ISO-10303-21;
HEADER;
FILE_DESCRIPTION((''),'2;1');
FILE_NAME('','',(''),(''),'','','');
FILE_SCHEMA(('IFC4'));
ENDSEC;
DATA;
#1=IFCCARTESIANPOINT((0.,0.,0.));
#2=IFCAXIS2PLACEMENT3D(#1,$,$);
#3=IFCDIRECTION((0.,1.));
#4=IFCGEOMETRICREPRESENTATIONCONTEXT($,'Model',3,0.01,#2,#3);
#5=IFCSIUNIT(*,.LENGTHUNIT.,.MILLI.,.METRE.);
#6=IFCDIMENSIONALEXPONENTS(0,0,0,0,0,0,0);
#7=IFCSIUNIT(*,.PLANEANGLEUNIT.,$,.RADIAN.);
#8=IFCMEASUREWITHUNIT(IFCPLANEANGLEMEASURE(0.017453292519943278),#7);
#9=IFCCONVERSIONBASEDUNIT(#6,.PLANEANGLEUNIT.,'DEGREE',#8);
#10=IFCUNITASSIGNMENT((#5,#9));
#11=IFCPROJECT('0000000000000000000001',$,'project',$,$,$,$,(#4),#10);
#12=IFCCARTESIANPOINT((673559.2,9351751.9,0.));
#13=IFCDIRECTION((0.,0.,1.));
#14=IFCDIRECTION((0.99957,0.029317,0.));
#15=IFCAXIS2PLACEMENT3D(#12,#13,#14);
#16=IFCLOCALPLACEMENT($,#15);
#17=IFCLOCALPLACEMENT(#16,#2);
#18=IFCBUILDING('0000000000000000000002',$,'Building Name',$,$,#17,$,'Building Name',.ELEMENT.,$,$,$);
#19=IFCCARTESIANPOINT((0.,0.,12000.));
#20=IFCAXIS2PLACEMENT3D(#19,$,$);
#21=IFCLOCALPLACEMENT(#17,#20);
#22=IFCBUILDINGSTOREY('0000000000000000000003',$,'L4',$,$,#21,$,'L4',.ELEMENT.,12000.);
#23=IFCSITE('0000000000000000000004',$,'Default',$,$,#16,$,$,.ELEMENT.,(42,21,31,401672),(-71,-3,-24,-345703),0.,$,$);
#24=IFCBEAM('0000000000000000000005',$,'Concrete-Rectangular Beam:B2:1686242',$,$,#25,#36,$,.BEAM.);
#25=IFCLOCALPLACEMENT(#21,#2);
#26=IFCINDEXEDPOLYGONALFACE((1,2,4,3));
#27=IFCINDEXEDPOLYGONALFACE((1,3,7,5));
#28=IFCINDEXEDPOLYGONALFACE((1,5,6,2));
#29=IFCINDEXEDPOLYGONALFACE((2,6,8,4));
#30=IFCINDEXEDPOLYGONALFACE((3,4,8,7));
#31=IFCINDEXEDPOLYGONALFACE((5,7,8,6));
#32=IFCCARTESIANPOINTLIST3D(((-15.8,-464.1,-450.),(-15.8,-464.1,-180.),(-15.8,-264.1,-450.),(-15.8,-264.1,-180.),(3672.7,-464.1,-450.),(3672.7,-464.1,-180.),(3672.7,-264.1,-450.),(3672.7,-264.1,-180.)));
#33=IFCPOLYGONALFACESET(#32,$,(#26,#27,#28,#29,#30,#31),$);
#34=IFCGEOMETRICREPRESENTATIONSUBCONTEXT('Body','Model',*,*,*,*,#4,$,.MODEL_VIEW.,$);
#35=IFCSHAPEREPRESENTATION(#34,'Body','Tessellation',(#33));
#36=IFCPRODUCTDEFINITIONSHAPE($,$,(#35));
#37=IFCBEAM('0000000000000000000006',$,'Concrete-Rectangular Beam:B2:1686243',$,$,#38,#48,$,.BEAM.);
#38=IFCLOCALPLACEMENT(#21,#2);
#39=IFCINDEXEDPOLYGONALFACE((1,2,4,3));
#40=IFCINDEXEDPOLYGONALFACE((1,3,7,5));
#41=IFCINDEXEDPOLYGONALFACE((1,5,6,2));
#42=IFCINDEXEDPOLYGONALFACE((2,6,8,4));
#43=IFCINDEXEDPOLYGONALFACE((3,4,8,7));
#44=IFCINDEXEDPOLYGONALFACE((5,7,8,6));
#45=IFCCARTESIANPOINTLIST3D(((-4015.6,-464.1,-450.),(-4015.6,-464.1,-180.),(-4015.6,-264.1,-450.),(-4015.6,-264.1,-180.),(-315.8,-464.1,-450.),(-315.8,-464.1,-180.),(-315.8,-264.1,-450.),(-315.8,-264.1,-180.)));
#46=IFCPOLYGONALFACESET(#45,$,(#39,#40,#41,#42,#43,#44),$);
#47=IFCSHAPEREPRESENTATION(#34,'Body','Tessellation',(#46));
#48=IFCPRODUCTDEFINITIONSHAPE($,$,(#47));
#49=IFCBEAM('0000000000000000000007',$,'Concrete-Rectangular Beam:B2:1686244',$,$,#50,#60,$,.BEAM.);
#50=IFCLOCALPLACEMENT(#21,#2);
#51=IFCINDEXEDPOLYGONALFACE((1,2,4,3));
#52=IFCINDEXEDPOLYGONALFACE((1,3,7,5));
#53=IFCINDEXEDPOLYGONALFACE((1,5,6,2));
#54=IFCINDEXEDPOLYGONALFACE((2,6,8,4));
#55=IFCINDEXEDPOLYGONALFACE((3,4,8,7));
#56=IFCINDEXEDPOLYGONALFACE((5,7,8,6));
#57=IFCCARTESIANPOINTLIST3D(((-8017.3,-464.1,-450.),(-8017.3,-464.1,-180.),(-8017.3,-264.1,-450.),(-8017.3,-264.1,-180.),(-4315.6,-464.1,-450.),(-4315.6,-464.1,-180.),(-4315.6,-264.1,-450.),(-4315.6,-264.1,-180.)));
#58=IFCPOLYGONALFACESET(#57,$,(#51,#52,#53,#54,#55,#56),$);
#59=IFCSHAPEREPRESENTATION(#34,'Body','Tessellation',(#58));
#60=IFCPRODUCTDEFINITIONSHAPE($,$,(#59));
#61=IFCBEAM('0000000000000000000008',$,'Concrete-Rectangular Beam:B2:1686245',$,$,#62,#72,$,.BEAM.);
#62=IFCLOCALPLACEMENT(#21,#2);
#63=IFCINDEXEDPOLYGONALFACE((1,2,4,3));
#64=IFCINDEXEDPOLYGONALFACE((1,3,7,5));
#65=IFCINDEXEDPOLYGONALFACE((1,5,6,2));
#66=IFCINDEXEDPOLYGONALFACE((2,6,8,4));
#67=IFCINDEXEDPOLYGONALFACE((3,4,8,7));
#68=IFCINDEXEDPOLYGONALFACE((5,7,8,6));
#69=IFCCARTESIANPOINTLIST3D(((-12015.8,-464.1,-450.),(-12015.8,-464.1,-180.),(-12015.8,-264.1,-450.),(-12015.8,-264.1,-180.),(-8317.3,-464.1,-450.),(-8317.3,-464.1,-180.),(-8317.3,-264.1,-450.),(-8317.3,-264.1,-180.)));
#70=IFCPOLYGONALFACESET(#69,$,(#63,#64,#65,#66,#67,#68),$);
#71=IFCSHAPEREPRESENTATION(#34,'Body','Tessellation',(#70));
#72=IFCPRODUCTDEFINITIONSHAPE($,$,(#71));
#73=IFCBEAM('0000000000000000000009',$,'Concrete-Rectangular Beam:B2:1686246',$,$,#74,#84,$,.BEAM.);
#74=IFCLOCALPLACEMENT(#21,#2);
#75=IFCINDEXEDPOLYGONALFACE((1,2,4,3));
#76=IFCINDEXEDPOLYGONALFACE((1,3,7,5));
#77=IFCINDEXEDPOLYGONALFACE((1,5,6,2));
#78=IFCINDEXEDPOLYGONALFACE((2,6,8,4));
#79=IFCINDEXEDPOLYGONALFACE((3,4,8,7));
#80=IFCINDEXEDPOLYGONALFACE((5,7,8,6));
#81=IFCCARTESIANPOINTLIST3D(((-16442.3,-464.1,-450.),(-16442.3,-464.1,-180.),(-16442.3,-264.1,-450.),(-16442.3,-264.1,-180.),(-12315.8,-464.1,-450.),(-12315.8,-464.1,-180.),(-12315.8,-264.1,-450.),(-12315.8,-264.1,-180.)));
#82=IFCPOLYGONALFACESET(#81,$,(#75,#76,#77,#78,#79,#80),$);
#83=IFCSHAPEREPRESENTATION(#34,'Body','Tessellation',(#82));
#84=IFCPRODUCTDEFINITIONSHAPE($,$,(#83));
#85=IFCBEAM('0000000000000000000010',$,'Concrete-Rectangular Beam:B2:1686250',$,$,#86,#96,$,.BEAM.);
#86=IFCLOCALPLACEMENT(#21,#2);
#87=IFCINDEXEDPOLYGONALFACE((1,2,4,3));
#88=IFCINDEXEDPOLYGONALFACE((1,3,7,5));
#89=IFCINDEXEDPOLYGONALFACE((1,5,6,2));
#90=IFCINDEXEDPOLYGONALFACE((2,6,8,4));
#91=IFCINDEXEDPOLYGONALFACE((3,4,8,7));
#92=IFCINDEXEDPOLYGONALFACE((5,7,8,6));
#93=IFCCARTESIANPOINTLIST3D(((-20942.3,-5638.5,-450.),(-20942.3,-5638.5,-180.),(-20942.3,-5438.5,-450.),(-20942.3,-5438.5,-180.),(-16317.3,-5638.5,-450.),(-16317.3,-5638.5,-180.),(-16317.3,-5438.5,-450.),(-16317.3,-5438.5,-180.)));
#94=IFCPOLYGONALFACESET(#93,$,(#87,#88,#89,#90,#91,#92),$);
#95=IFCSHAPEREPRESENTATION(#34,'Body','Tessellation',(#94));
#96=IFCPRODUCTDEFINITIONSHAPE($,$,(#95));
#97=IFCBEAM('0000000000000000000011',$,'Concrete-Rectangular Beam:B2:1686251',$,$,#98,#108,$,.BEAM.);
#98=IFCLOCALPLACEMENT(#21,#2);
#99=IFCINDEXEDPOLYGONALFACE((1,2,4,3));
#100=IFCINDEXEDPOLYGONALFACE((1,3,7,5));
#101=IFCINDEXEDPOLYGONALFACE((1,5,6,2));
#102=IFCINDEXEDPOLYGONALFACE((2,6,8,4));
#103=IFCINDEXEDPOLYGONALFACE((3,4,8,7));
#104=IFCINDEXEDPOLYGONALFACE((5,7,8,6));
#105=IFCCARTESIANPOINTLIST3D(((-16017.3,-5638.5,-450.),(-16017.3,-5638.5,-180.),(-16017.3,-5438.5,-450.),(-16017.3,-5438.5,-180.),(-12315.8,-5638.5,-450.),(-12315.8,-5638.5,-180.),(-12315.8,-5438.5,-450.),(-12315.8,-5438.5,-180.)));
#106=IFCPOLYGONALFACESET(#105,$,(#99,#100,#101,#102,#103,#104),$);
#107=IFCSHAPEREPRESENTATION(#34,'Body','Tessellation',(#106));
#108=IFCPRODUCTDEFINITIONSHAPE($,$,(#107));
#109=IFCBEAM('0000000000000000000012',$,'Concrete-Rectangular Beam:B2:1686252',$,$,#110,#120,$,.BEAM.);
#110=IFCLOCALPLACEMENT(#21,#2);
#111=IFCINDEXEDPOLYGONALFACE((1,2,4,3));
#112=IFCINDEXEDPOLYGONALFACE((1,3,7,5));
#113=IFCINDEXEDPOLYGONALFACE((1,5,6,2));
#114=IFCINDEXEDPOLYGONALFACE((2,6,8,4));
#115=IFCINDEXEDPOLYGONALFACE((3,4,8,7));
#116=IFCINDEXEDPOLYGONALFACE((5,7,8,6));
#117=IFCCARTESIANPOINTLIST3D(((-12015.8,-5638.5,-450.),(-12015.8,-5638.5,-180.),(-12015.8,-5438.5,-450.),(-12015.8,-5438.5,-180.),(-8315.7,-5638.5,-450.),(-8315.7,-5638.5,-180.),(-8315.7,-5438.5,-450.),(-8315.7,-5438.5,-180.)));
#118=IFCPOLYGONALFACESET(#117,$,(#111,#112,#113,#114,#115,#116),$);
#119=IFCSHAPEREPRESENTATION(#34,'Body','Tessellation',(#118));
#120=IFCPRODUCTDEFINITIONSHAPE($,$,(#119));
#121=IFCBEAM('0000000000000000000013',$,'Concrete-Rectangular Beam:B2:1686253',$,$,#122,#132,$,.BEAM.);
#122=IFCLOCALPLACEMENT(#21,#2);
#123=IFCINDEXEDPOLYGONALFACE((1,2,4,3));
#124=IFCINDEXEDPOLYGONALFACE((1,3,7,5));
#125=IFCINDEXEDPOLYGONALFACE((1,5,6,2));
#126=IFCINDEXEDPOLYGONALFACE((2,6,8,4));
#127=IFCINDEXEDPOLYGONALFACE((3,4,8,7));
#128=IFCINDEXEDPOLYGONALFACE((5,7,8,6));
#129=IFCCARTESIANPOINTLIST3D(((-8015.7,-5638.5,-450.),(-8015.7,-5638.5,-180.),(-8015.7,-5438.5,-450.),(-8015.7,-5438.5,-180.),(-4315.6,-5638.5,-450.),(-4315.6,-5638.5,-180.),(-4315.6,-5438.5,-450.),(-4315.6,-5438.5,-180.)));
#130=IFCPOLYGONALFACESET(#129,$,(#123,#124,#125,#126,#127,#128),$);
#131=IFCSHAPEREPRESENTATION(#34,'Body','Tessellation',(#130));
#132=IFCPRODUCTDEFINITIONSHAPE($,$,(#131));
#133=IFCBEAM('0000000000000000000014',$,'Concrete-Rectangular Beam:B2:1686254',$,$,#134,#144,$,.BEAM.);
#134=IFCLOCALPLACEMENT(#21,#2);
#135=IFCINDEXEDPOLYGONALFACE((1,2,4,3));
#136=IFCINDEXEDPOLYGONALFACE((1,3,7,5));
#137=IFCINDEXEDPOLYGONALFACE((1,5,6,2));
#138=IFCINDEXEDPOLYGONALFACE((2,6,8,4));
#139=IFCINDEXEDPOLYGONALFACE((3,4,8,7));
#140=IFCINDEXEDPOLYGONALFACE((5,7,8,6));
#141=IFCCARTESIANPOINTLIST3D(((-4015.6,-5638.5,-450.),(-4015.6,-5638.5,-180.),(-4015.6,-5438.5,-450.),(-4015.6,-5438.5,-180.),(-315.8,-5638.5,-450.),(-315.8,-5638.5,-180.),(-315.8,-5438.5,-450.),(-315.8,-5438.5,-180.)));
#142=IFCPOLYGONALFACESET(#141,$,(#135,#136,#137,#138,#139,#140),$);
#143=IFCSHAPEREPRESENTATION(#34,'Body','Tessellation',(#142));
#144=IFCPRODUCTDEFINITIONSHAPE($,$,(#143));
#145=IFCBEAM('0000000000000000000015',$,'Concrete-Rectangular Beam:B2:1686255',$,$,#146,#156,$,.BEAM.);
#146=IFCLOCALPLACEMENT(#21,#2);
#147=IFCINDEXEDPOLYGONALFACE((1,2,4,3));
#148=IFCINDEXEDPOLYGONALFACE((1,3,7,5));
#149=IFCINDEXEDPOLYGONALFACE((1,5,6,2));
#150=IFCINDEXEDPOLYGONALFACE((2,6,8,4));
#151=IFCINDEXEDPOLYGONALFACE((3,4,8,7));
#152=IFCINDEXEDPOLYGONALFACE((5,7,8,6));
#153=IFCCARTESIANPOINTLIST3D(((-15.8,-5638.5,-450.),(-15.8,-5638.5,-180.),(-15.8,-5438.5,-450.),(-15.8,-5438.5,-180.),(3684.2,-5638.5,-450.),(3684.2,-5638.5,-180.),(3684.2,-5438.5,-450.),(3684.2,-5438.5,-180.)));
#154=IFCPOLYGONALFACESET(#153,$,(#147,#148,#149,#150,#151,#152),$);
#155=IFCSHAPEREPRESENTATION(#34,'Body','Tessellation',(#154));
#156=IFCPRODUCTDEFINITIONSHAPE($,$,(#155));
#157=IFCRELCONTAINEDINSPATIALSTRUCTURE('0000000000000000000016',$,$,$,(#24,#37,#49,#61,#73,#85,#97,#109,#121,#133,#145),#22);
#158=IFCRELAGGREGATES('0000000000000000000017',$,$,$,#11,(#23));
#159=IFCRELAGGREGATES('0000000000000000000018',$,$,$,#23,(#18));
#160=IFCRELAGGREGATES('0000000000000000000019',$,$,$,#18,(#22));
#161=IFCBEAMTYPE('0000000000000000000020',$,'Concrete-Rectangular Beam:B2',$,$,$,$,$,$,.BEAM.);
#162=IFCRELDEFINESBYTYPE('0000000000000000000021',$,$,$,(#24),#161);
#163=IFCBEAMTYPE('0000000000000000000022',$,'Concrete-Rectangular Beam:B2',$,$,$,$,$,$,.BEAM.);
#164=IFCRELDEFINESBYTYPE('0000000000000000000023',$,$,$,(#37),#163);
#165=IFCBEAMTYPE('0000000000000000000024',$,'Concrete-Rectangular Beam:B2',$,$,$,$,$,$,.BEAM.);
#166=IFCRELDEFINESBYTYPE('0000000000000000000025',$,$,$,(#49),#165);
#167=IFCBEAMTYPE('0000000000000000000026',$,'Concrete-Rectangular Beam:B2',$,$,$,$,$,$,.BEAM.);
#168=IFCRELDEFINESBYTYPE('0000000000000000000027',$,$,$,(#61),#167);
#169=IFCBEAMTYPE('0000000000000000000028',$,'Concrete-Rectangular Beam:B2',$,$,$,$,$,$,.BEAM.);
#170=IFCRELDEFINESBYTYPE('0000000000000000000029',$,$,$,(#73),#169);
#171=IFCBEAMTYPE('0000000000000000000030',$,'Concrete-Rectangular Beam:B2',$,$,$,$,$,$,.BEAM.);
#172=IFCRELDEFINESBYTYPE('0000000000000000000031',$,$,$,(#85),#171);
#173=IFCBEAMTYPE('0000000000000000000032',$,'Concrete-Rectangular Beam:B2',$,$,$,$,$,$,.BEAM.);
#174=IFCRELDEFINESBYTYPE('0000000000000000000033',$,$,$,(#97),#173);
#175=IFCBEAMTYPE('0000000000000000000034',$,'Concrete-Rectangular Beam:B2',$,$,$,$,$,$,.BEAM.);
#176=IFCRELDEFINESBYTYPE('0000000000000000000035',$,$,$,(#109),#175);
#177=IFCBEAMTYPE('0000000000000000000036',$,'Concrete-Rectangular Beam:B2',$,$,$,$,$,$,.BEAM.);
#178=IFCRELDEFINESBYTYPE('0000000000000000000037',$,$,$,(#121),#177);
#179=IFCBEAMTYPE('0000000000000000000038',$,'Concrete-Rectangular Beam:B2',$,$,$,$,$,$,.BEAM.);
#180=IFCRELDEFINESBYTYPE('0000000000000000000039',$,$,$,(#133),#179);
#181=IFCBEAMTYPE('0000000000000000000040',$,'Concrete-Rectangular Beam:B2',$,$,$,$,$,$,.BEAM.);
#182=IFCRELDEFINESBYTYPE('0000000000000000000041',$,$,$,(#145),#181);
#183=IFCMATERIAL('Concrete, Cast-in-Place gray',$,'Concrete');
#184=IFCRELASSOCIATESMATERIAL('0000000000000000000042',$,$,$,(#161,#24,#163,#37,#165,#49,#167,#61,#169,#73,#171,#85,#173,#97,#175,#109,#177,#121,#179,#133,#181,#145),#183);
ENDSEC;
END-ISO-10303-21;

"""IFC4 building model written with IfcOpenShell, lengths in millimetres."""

from ifc_helpers import new_model, entity, si_unit, converted_unit, direction, frame, origin, place, context, subcontext, project, spatial, indexed_curve, outline, extrude, source, transform, mapped, material, type_object, type_shapes, element, save


model = new_model("IFC4")

# Units and contexts
model_context = context("Model", 3, precision=0.01, world=origin(), true_north=direction((0.0, 1.0)))
body_context = subcontext(model_context, "Body", "Model", "MODEL_VIEW")
ifc_project = project(units=[si_unit("LENGTHUNIT", "METRE", prefix="MILLI"), converted_unit("PLANEANGLEUNIT", "DEGREE", entity("IfcPlaneAngleMeasure", 0.017453292519943278), si_unit("PLANEANGLEUNIT", "RADIAN"), dimensions=[0, 0, 0, 0, 0, 0, 0])], contexts=[model_context])

# Site, building, storey
site_placement = place(None, frame((673559.2, 9351751.9, 0.0), z_axis=(0.0, 0.0, 1.0), x_axis=(0.99957, 0.029317, 0.0)))
site = spatial("IfcSite", under=ifc_project, at=site_placement, Name="Default", CompositionType="ELEMENT", RefLatitude=(42, 21, 31, 401672), RefLongitude=(-71, -3, -24, -345703), RefElevation=0.0)
building_placement = place(site_placement, origin())
building = spatial("IfcBuilding", under=site, at=building_placement, Name="Building Name", LongName="Building Name", CompositionType="ELEMENT")
storey_placement = place(building_placement, frame((0.0, 0.0, 12000.0)))
storey = spatial("IfcBuildingStorey", under=building, at=storey_placement, Name="L4", LongName="L4", CompositionType="ELEMENT", Elevation=12000.0)

# Beams
ifc_material = material(Name="Concrete, Cast-in-Place gray", Category="Concrete")
beam_type_1 = type_object("IfcBeamType", Name="Concrete-Rectangular Beam:B2", PredefinedType="BEAM", material=ifc_material)
shared_shape_1 = source(origin(), body_context, "Body", "SweptSolid", [
    extrude(outline(indexed_curve([(-135.0, -100.0), (135.0, -100.0), (135.0, 100.0), (-135.0, 100.0), (-135.0, -100.0)], self_intersect=False)), frame((3672.7, -364.1, 11685.0), z_axis=(-1.0, 0.0, 0.0), x_axis=(0.0, 0.0, -1.0)), (0.0, 0.0, 1.0), 3688.6),
])
type_shapes(beam_type_1, [shared_shape_1])
beam_1_placement = place(storey_placement, frame((0.0, 0.0, -12000.0)))
element("IfcBeam", 1, at=beam_1_placement, inside=storey, type_object=beam_type_1, material=ifc_material, Name="Concrete-Rectangular Beam:B2:1686242", PredefinedType="BEAM", context=body_context, shape_type="MappedRepresentation", body=[
    mapped(shared_shape_1, transform((0.0, 0.0, 0.0), scale=1.0)),
])
beam_type_2 = type_object("IfcBeamType", Name="Concrete-Rectangular Beam:B2", PredefinedType="BEAM", material=ifc_material)
shared_shape_2 = source(origin(), body_context, "Body", "SweptSolid", [
    extrude(outline(indexed_curve([(-135.0, -100.0), (135.0, -100.0), (135.0, 100.0), (-135.0, 100.0), (-135.0, -100.0)], self_intersect=False)), frame((-315.8, -364.1, 11685.0), z_axis=(-1.0, 0.0, 0.0), x_axis=(0.0, 0.0, -1.0)), (0.0, 0.0, 1.0), 3699.7),
])
type_shapes(beam_type_2, [shared_shape_2])
beam_2_placement = place(storey_placement, frame((0.0, 0.0, -12000.0)))
element("IfcBeam", 2, at=beam_2_placement, inside=storey, type_object=beam_type_2, material=ifc_material, Name="Concrete-Rectangular Beam:B2:1686243", PredefinedType="BEAM", context=body_context, shape_type="MappedRepresentation", body=[
    mapped(shared_shape_2, transform((0.0, 0.0, 0.0), scale=1.0)),
])
beam_type_3 = type_object("IfcBeamType", Name="Concrete-Rectangular Beam:B2", PredefinedType="BEAM", material=ifc_material)
shared_shape_3 = source(origin(), body_context, "Body", "SweptSolid", [
    extrude(outline(indexed_curve([(-135.0, -100.0), (135.0, -100.0), (135.0, 100.0), (-135.0, 100.0), (-135.0, -100.0)], self_intersect=False)), frame((-4315.6, -364.1, 11685.0), z_axis=(-1.0, 0.0, 0.0), x_axis=(0.0, 0.0, -1.0)), (0.0, 0.0, 1.0), 3701.8),
])
type_shapes(beam_type_3, [shared_shape_3])
beam_3_placement = place(storey_placement, frame((0.0, 0.0, -12000.0)))
element("IfcBeam", 3, at=beam_3_placement, inside=storey, type_object=beam_type_3, material=ifc_material, Name="Concrete-Rectangular Beam:B2:1686244", PredefinedType="BEAM", context=body_context, shape_type="MappedRepresentation", body=[
    mapped(shared_shape_3, transform((0.0, 0.0, 0.0), scale=1.0)),
])
beam_type_4 = type_object("IfcBeamType", Name="Concrete-Rectangular Beam:B2", PredefinedType="BEAM", material=ifc_material)
shared_shape_4 = source(origin(), body_context, "Body", "SweptSolid", [
    extrude(outline(indexed_curve([(-135.0, -100.0), (135.0, -100.0), (135.0, 100.0), (-135.0, 100.0), (-135.0, -100.0)], self_intersect=False)), frame((-8317.3, -364.1, 11685.0), z_axis=(-1.0, 0.0, 0.0), x_axis=(0.0, 0.0, -1.0)), (0.0, 0.0, 1.0), 3698.5),
])
type_shapes(beam_type_4, [shared_shape_4])
beam_4_placement = place(storey_placement, frame((0.0, 0.0, -12000.0)))
element("IfcBeam", 4, at=beam_4_placement, inside=storey, type_object=beam_type_4, material=ifc_material, Name="Concrete-Rectangular Beam:B2:1686245", PredefinedType="BEAM", context=body_context, shape_type="MappedRepresentation", body=[
    mapped(shared_shape_4, transform((0.0, 0.0, 0.0), scale=1.0)),
])
beam_type_5 = type_object("IfcBeamType", Name="Concrete-Rectangular Beam:B2", PredefinedType="BEAM", material=ifc_material)
shared_shape_5 = source(origin(), body_context, "Body", "SweptSolid", [
    extrude(outline(indexed_curve([(-135.0, -100.0), (135.0, -100.0), (135.0, 100.0), (-135.0, 100.0), (-135.0, -100.0)], self_intersect=False)), frame((-12315.8, -364.1, 11685.0), z_axis=(-1.0, 0.0, 0.0), x_axis=(0.0, 0.0, -1.0)), (0.0, 0.0, 1.0), 4126.5),
])
type_shapes(beam_type_5, [shared_shape_5])
beam_5_placement = place(storey_placement, frame((0.0, 0.0, -12000.0)))
element("IfcBeam", 5, at=beam_5_placement, inside=storey, type_object=beam_type_5, material=ifc_material, Name="Concrete-Rectangular Beam:B2:1686246", PredefinedType="BEAM", context=body_context, shape_type="MappedRepresentation", body=[
    mapped(shared_shape_5, transform((0.0, 0.0, 0.0), scale=1.0)),
])
beam_type_6 = type_object("IfcBeamType", Name="Concrete-Rectangular Beam:B2", PredefinedType="BEAM", material=ifc_material)
shared_shape_6 = source(origin(), body_context, "Body", "SweptSolid", [
    extrude(outline(indexed_curve([(-135.0, -100.0), (135.0, -100.0), (135.0, 100.0), (-135.0, 100.0), (-135.0, -100.0)], self_intersect=False)), frame((-20942.3, -5538.5, 11685.0), z_axis=(1.0, 0.0, 0.0), x_axis=(0.0, 0.0, -1.0)), (0.0, 0.0, 1.0), 4625.0),
])
type_shapes(beam_type_6, [shared_shape_6])
beam_6_placement = place(storey_placement, frame((0.0, 0.0, -12000.0)))
element("IfcBeam", 6, at=beam_6_placement, inside=storey, type_object=beam_type_6, material=ifc_material, Name="Concrete-Rectangular Beam:B2:1686250", PredefinedType="BEAM", context=body_context, shape_type="MappedRepresentation", body=[
    mapped(shared_shape_6, transform((0.0, 0.0, 0.0), scale=1.0)),
])
beam_type_7 = type_object("IfcBeamType", Name="Concrete-Rectangular Beam:B2", PredefinedType="BEAM", material=ifc_material)
shared_shape_7 = source(origin(), body_context, "Body", "SweptSolid", [
    extrude(outline(indexed_curve([(-135.0, -100.0), (135.0, -100.0), (135.0, 100.0), (-135.0, 100.0), (-135.0, -100.0)], self_intersect=False)), frame((-16017.3, -5538.5, 11685.0), z_axis=(1.0, 0.0, 0.0), x_axis=(0.0, 0.0, -1.0)), (0.0, 0.0, 1.0), 3701.5),
])
type_shapes(beam_type_7, [shared_shape_7])
beam_7_placement = place(storey_placement, frame((0.0, 0.0, -12000.0)))
element("IfcBeam", 7, at=beam_7_placement, inside=storey, type_object=beam_type_7, material=ifc_material, Name="Concrete-Rectangular Beam:B2:1686251", PredefinedType="BEAM", context=body_context, shape_type="MappedRepresentation", body=[
    mapped(shared_shape_7, transform((0.0, 0.0, 0.0), scale=1.0)),
])
beam_type_8 = type_object("IfcBeamType", Name="Concrete-Rectangular Beam:B2", PredefinedType="BEAM", material=ifc_material)
shared_shape_8 = source(origin(), body_context, "Body", "SweptSolid", [
    extrude(outline(indexed_curve([(-135.0, -100.0), (135.0, -100.0), (135.0, 100.0), (-135.0, 100.0), (-135.0, -100.0)], self_intersect=False)), frame((-8315.7, -5538.5, 11685.0), z_axis=(-1.0, 0.0, 0.0), x_axis=(0.0, 0.0, -1.0)), (0.0, 0.0, 1.0), 3700.1),
])
type_shapes(beam_type_8, [shared_shape_8])
beam_8_placement = place(storey_placement, frame((0.0, 0.0, -12000.0)))
element("IfcBeam", 8, at=beam_8_placement, inside=storey, type_object=beam_type_8, material=ifc_material, Name="Concrete-Rectangular Beam:B2:1686252", PredefinedType="BEAM", context=body_context, shape_type="MappedRepresentation", body=[
    mapped(shared_shape_8, transform((0.0, 0.0, 0.0), scale=1.0)),
])
beam_type_9 = type_object("IfcBeamType", Name="Concrete-Rectangular Beam:B2", PredefinedType="BEAM", material=ifc_material)
shared_shape_9 = source(origin(), body_context, "Body", "SweptSolid", [
    extrude(outline(indexed_curve([(-135.0, -100.0), (135.0, -100.0), (135.0, 100.0), (-135.0, 100.0), (-135.0, -100.0)], self_intersect=False)), frame((-8015.7, -5538.5, 11685.0), z_axis=(1.0, 0.0, 0.0), x_axis=(0.0, 0.0, -1.0)), (0.0, 0.0, 1.0), 3700.1),
])
type_shapes(beam_type_9, [shared_shape_9])
beam_9_placement = place(storey_placement, frame((0.0, 0.0, -12000.0)))
element("IfcBeam", 9, at=beam_9_placement, inside=storey, type_object=beam_type_9, material=ifc_material, Name="Concrete-Rectangular Beam:B2:1686253", PredefinedType="BEAM", context=body_context, shape_type="MappedRepresentation", body=[
    mapped(shared_shape_9, transform((0.0, 0.0, 0.0), scale=1.0)),
])
beam_type_10 = type_object("IfcBeamType", Name="Concrete-Rectangular Beam:B2", PredefinedType="BEAM", material=ifc_material)
shared_shape_10 = source(origin(), body_context, "Body", "SweptSolid", [
    extrude(outline(indexed_curve([(-135.0, -100.0), (135.0, -100.0), (135.0, 100.0), (-135.0, 100.0), (-135.0, -100.0)], self_intersect=False)), frame((-4015.6, -5538.5, 11685.0), z_axis=(1.0, 0.0, 0.0), x_axis=(0.0, 0.0, -1.0)), (0.0, 0.0, 1.0), 3699.7),
])
type_shapes(beam_type_10, [shared_shape_10])
beam_10_placement = place(storey_placement, frame((0.0, 0.0, -12000.0)))
element("IfcBeam", 10, at=beam_10_placement, inside=storey, type_object=beam_type_10, material=ifc_material, Name="Concrete-Rectangular Beam:B2:1686254", PredefinedType="BEAM", context=body_context, shape_type="MappedRepresentation", body=[
    mapped(shared_shape_10, transform((0.0, 0.0, 0.0), scale=1.0)),
])
beam_type_11 = type_object("IfcBeamType", Name="Concrete-Rectangular Beam:B2", PredefinedType="BEAM", material=ifc_material)
shared_shape_11 = source(origin(), body_context, "Body", "SweptSolid", [
    extrude(outline(indexed_curve([(-135.0, -100.0), (135.0, -100.0), (135.0, 100.0), (-135.0, 100.0), (-135.0, -100.0)], self_intersect=False)), frame((-15.8, -5538.5, 11685.0), z_axis=(1.0, 0.0, 0.0), x_axis=(0.0, 0.0, -1.0)), (0.0, 0.0, 1.0), 3700.0),
])
type_shapes(beam_type_11, [shared_shape_11])
beam_11_placement = place(storey_placement, frame((0.0, 0.0, -12000.0)))
element("IfcBeam", 11, at=beam_11_placement, inside=storey, type_object=beam_type_11, material=ifc_material, Name="Concrete-Rectangular Beam:B2:1686255", PredefinedType="BEAM", context=body_context, shape_type="MappedRepresentation", body=[
    mapped(shared_shape_11, transform((0.0, 0.0, 0.0), scale=1.0)),
])

save(model, "model.ifc")
